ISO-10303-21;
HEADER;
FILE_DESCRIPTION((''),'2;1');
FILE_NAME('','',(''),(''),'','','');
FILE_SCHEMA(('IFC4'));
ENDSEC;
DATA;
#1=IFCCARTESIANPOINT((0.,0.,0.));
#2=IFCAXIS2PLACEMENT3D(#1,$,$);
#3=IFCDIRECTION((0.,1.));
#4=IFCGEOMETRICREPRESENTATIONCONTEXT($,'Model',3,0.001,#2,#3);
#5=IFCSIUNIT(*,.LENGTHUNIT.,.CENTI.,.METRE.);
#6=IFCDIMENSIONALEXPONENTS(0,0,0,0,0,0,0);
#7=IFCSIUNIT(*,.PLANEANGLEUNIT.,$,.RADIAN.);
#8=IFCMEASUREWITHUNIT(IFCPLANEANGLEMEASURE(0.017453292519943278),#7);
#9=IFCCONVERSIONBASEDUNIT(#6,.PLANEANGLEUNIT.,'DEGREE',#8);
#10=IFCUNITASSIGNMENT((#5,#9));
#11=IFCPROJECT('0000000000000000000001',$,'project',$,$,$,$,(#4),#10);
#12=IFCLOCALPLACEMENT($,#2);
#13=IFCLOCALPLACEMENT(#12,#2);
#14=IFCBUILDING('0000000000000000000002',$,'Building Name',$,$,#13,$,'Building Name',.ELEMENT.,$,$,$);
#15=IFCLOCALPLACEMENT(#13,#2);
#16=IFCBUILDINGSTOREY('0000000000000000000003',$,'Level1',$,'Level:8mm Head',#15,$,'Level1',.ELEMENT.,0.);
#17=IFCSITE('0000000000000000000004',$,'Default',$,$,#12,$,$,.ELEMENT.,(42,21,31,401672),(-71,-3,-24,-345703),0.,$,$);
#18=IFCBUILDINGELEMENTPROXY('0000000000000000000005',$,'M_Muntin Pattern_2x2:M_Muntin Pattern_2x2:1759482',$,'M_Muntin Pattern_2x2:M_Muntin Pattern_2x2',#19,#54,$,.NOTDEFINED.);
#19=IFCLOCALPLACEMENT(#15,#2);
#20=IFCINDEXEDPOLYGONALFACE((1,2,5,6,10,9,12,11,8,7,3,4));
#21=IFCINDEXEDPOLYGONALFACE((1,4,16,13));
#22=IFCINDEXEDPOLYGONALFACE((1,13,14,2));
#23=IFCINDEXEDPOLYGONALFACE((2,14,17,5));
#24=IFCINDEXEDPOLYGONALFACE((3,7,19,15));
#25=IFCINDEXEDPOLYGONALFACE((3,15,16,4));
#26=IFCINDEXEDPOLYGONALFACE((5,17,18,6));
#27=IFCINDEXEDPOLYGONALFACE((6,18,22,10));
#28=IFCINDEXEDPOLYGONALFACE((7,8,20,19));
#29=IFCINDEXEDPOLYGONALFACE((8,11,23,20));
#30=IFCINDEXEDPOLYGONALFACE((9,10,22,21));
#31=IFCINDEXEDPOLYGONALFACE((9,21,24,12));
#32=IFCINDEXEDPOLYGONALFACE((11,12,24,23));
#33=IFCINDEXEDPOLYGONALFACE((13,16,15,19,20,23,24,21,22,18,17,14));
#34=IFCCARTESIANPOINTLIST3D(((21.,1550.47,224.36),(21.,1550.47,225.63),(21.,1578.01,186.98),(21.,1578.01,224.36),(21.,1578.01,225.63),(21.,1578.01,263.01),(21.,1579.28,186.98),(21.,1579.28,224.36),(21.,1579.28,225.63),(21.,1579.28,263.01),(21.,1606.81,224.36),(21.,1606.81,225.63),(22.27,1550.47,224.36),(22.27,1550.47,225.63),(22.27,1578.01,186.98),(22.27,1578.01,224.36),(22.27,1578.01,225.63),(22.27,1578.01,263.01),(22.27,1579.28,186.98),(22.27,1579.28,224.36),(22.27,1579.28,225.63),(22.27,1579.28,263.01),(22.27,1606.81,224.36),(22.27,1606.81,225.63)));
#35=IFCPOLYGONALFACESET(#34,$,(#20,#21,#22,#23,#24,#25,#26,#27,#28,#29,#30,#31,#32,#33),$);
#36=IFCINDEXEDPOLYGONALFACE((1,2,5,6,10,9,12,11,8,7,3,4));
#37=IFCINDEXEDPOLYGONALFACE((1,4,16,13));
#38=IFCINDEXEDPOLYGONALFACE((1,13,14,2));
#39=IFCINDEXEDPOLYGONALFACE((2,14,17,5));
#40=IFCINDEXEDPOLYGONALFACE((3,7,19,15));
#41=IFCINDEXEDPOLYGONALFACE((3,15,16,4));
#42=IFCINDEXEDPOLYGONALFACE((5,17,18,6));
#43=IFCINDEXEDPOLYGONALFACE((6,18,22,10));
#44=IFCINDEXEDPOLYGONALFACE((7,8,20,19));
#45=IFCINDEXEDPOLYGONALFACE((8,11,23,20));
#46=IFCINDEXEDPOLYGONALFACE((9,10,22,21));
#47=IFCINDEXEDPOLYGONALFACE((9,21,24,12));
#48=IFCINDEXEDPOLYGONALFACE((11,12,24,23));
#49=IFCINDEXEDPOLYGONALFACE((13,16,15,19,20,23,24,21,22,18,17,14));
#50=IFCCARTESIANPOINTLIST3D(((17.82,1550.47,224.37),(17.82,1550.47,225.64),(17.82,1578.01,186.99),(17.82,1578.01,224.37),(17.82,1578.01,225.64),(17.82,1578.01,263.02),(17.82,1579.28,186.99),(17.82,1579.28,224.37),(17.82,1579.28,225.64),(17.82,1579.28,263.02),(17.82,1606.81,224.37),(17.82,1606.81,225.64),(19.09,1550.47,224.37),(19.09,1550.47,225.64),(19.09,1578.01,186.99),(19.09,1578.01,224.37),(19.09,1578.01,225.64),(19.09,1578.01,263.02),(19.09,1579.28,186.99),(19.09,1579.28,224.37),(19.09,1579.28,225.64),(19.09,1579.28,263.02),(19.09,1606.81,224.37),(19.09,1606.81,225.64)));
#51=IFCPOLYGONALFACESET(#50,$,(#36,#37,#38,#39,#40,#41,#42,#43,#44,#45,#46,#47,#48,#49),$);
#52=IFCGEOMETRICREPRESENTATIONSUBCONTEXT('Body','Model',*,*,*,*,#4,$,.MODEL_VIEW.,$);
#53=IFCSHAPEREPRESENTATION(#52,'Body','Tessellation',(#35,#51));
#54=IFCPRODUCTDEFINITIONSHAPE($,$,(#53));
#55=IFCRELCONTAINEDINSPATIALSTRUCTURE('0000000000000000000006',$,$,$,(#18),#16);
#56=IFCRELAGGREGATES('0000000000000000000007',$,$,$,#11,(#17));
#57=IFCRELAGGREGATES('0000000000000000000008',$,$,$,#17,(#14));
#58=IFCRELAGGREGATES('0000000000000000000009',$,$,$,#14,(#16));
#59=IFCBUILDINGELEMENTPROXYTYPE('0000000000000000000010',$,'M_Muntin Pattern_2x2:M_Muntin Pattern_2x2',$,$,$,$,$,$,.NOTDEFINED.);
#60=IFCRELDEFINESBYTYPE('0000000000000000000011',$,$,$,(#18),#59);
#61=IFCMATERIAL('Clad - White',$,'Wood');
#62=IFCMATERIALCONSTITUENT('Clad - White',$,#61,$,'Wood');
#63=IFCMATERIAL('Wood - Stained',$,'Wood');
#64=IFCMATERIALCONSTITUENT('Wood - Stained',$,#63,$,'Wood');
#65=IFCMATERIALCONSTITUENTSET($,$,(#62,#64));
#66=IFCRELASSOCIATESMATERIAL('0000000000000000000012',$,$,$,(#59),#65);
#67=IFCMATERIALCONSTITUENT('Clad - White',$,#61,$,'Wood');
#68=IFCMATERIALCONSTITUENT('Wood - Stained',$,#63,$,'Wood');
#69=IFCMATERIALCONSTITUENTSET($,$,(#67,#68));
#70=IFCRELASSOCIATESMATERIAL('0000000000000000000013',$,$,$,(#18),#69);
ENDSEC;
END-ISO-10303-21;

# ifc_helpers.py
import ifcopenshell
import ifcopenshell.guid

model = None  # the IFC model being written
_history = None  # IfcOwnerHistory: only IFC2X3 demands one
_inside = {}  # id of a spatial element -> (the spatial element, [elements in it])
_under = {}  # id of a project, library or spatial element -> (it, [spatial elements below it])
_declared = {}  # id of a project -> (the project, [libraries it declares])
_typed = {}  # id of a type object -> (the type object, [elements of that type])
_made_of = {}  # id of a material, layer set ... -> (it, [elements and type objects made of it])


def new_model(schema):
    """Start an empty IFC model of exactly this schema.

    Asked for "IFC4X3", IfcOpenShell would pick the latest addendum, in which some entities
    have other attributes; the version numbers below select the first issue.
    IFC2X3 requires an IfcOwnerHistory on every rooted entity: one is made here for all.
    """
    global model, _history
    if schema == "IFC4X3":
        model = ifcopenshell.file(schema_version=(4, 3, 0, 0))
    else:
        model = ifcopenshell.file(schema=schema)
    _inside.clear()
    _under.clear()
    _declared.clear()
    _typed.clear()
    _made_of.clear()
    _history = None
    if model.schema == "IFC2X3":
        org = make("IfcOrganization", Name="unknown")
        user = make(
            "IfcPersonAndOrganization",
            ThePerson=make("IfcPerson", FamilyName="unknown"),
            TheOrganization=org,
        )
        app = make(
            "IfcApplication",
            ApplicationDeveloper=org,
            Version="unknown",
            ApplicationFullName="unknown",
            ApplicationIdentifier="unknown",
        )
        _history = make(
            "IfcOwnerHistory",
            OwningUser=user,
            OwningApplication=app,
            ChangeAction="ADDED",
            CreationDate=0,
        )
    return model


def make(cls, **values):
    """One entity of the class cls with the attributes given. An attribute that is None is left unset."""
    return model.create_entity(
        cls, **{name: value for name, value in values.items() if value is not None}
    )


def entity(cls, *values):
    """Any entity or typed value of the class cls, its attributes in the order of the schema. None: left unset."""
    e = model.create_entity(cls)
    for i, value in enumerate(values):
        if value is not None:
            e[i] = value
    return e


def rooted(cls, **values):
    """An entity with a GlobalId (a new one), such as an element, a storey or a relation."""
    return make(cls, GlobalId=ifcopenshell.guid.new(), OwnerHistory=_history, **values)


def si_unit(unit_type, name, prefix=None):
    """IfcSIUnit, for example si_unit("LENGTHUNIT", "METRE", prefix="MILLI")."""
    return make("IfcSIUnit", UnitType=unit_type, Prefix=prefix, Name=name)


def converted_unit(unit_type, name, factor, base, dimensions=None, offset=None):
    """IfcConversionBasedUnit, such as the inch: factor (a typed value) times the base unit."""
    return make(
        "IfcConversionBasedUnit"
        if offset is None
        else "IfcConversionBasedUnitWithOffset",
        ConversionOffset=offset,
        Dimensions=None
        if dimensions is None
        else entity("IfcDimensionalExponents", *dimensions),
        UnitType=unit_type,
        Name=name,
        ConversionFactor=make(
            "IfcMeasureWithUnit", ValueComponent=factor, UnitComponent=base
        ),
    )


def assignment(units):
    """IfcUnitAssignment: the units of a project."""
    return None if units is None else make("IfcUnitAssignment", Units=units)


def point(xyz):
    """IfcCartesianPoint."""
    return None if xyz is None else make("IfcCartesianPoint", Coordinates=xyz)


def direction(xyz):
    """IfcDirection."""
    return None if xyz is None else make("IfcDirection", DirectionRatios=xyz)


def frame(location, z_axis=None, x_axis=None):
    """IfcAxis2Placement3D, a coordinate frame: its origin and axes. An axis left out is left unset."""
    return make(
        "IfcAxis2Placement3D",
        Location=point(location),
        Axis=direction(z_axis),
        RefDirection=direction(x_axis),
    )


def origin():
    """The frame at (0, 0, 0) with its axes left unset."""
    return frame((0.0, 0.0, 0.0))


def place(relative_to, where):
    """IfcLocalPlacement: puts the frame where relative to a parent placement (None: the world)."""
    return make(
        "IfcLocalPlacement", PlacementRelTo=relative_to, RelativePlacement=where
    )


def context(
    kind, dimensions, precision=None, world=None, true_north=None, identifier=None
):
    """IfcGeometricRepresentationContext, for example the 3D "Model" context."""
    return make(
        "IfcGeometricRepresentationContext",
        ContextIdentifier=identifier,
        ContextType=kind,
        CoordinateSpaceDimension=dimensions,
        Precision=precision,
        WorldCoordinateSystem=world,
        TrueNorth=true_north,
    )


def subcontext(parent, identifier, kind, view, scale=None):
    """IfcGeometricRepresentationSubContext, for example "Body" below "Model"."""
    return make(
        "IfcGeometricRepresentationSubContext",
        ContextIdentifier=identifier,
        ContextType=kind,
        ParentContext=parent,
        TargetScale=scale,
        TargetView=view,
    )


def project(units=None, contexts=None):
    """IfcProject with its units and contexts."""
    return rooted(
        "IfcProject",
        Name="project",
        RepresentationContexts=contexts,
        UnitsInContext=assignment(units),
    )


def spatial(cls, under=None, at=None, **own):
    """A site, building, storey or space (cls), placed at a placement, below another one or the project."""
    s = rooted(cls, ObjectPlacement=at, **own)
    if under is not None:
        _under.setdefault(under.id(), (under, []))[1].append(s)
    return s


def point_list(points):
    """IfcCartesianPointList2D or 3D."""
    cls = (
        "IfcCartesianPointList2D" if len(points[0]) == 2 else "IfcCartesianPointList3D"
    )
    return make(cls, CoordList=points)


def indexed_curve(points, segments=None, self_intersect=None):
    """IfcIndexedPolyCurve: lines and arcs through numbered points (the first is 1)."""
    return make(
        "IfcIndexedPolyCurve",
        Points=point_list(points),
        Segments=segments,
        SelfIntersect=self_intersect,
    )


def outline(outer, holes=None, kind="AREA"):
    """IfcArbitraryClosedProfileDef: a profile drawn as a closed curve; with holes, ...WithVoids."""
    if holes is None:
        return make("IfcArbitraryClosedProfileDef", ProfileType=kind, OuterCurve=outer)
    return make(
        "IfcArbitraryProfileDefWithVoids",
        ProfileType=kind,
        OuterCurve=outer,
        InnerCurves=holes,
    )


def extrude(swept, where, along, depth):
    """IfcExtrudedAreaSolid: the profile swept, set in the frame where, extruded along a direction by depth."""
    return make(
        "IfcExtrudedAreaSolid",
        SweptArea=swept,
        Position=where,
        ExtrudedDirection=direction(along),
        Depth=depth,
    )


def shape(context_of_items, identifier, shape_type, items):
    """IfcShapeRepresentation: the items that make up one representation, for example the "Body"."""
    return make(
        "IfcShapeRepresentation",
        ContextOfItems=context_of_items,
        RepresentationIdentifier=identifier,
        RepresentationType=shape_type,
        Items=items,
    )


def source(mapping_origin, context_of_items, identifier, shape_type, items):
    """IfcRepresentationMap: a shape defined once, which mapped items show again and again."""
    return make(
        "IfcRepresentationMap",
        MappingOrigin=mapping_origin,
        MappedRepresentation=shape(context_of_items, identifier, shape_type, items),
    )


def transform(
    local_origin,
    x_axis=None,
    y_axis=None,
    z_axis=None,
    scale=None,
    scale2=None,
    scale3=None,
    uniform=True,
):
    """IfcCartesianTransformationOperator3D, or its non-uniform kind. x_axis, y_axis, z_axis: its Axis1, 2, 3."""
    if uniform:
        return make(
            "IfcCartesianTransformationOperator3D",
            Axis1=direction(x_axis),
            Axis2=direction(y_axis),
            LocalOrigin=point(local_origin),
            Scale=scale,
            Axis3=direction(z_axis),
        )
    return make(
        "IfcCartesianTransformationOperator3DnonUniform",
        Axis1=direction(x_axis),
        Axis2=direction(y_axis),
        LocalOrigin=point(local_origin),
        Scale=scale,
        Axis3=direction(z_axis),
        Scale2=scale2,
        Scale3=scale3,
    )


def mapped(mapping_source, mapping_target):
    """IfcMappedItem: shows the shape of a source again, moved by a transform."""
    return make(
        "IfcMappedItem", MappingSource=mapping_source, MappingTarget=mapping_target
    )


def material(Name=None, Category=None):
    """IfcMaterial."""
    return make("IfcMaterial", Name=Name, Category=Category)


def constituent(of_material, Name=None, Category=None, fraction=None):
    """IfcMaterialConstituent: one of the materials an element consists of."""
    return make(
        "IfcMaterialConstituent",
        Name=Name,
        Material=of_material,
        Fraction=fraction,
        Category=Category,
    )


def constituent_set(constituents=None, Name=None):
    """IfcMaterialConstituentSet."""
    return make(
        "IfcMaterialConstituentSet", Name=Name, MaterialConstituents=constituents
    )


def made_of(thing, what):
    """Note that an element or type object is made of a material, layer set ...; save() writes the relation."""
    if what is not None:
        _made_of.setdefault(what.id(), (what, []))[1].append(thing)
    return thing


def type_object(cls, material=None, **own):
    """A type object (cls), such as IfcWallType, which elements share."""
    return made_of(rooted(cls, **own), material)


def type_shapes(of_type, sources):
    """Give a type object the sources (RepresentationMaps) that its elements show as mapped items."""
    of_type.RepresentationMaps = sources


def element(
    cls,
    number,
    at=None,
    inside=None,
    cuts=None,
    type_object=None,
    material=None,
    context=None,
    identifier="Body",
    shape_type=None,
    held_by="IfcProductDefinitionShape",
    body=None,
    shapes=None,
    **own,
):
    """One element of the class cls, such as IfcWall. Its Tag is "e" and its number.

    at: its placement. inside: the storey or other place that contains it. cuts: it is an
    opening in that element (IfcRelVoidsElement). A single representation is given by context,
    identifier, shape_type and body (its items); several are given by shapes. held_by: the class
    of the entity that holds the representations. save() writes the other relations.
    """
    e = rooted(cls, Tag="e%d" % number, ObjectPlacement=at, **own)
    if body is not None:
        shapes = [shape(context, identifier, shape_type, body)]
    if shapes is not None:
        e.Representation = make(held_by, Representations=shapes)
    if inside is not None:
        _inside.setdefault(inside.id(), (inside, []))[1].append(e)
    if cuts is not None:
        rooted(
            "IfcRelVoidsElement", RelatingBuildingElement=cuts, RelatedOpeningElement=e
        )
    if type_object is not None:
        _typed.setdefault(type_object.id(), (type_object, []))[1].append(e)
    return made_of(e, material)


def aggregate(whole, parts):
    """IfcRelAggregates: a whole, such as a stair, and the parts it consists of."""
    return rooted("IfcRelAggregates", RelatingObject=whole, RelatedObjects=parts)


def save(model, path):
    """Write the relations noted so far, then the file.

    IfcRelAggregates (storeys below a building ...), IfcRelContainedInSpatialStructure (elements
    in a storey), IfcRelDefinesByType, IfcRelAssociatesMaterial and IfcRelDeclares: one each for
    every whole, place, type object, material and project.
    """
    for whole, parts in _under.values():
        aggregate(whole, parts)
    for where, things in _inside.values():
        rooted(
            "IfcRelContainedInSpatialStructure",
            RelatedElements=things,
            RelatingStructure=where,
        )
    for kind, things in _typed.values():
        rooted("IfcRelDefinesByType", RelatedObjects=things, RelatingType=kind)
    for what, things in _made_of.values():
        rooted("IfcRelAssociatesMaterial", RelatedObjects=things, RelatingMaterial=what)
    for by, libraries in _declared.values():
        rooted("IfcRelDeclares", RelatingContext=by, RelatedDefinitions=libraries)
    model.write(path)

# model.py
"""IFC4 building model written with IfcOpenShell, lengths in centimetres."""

from ifc_helpers import new_model, entity, si_unit, converted_unit, direction, frame, origin, place, context, subcontext, project, spatial, indexed_curve, outline, extrude, source, transform, mapped, material, constituent, constituent_set, type_object, type_shapes, element, save


model = new_model("IFC4")

# Units and contexts
model_context = context("Model", 3, precision=0.001, world=origin(), true_north=direction((0.0, 1.0)))
body_context = subcontext(model_context, "Body", "Model", "MODEL_VIEW")
ifc_project = project(units=[si_unit("LENGTHUNIT", "METRE", prefix="CENTI"), converted_unit("PLANEANGLEUNIT", "DEGREE", entity("IfcPlaneAngleMeasure", 0.017453292519943278), si_unit("PLANEANGLEUNIT", "RADIAN"), dimensions=[0, 0, 0, 0, 0, 0, 0])], contexts=[model_context])

# Site, building, storey
site_placement = place(None, origin())
site = spatial("IfcSite", under=ifc_project, at=site_placement, Name="Default", CompositionType="ELEMENT", RefLatitude=(42, 21, 31, 401672), RefLongitude=(-71, -3, -24, -345703), RefElevation=0.0)
building_placement = place(site_placement, origin())
building = spatial("IfcBuilding", under=site, at=building_placement, Name="Building Name", LongName="Building Name", CompositionType="ELEMENT")
storey_placement = place(building_placement, origin())
storey = spatial("IfcBuildingStorey", under=building, at=storey_placement, Name="Level1", ObjectType="Level:8mm Head", LongName="Level1", CompositionType="ELEMENT", Elevation=0.0)

# Shared definitions
ifc_material_1 = material(Name="Clad - White", Category="Wood")
ifc_material_2 = material(Name="Wood - Stained", Category="Wood")

# Building element proxy
ifc_constituent_1 = constituent(ifc_material_1, Name="Clad - White", Category="Wood")
ifc_constituent_2 = constituent(ifc_material_2, Name="Wood - Stained", Category="Wood")
ifc_constituent_set_1 = constituent_set(constituents=[ifc_constituent_1, ifc_constituent_2])
ifc_constituent_3 = constituent(ifc_material_1, Name="Clad - White", Category="Wood")
ifc_constituent_4 = constituent(ifc_material_2, Name="Wood - Stained", Category="Wood")
ifc_constituent_set_2 = constituent_set(constituents=[ifc_constituent_3, ifc_constituent_4])
building_element_proxy_type_1 = type_object("IfcBuildingElementProxyType", Name="M_Muntin Pattern_2x2:M_Muntin Pattern_2x2", PredefinedType="NOTDEFINED", material=ifc_constituent_set_2)
shared_shape_1 = source(origin(), body_context, "Body", "SweptSolid", [
    extrude(outline(indexed_curve([(0.64, -0.64), (38.01, -0.64), (38.01, 0.63), (0.64, 0.63), (0.64, 28.17), (-0.63, 28.17), (-0.63, 0.63), (-38.02, 0.63), (-38.02, -0.64), (-0.63, -0.64), (-0.63, -28.17), (0.64, -28.17), (0.64, -0.64)], self_intersect=False)), frame((0.0, 0.95, 38.01), z_axis=(0.0, 1.0, 0.0), x_axis=(0.0, 0.0, 1.0)), (0.0, 0.0, 1.0), 1.27),
    extrude(outline(indexed_curve([(0.64, -0.64), (38.02, -0.64), (38.02, 0.63), (0.64, 0.63), (0.64, 28.17), (-0.63, 28.17), (-0.63, 0.63), (-38.02, 0.63), (-38.02, -0.64), (-0.63, -0.64), (-0.63, -28.17), (0.64, -28.17), (0.64, -0.64)], self_intersect=False)), frame((0.0, -2.22, 38.02), z_axis=(0.0, 1.0, 0.0), x_axis=(0.0, 0.0, 1.0)), (0.0, 0.0, 1.0), 1.27),
])
type_shapes(building_element_proxy_type_1, [shared_shape_1])
proxy_1_placement = place(storey_placement, frame((20.05, 1578.64, 186.99), z_axis=(0.0, 0.0, 1.0), x_axis=(0.0, -1.0, 0.0)))
element("IfcBuildingElementProxy", 1, at=proxy_1_placement, inside=storey, type_object=building_element_proxy_type_1, material=ifc_constituent_set_1, Name="M_Muntin Pattern_2x2:M_Muntin Pattern_2x2:1759482", ObjectType="M_Muntin Pattern_2x2:M_Muntin Pattern_2x2", PredefinedType="NOTDEFINED", context=body_context, shape_type="MappedRepresentation", body=[
    mapped(shared_shape_1, transform((0.0, 0.0, 0.0), scale=1.0)),
])

save(model, "model.ifc")
